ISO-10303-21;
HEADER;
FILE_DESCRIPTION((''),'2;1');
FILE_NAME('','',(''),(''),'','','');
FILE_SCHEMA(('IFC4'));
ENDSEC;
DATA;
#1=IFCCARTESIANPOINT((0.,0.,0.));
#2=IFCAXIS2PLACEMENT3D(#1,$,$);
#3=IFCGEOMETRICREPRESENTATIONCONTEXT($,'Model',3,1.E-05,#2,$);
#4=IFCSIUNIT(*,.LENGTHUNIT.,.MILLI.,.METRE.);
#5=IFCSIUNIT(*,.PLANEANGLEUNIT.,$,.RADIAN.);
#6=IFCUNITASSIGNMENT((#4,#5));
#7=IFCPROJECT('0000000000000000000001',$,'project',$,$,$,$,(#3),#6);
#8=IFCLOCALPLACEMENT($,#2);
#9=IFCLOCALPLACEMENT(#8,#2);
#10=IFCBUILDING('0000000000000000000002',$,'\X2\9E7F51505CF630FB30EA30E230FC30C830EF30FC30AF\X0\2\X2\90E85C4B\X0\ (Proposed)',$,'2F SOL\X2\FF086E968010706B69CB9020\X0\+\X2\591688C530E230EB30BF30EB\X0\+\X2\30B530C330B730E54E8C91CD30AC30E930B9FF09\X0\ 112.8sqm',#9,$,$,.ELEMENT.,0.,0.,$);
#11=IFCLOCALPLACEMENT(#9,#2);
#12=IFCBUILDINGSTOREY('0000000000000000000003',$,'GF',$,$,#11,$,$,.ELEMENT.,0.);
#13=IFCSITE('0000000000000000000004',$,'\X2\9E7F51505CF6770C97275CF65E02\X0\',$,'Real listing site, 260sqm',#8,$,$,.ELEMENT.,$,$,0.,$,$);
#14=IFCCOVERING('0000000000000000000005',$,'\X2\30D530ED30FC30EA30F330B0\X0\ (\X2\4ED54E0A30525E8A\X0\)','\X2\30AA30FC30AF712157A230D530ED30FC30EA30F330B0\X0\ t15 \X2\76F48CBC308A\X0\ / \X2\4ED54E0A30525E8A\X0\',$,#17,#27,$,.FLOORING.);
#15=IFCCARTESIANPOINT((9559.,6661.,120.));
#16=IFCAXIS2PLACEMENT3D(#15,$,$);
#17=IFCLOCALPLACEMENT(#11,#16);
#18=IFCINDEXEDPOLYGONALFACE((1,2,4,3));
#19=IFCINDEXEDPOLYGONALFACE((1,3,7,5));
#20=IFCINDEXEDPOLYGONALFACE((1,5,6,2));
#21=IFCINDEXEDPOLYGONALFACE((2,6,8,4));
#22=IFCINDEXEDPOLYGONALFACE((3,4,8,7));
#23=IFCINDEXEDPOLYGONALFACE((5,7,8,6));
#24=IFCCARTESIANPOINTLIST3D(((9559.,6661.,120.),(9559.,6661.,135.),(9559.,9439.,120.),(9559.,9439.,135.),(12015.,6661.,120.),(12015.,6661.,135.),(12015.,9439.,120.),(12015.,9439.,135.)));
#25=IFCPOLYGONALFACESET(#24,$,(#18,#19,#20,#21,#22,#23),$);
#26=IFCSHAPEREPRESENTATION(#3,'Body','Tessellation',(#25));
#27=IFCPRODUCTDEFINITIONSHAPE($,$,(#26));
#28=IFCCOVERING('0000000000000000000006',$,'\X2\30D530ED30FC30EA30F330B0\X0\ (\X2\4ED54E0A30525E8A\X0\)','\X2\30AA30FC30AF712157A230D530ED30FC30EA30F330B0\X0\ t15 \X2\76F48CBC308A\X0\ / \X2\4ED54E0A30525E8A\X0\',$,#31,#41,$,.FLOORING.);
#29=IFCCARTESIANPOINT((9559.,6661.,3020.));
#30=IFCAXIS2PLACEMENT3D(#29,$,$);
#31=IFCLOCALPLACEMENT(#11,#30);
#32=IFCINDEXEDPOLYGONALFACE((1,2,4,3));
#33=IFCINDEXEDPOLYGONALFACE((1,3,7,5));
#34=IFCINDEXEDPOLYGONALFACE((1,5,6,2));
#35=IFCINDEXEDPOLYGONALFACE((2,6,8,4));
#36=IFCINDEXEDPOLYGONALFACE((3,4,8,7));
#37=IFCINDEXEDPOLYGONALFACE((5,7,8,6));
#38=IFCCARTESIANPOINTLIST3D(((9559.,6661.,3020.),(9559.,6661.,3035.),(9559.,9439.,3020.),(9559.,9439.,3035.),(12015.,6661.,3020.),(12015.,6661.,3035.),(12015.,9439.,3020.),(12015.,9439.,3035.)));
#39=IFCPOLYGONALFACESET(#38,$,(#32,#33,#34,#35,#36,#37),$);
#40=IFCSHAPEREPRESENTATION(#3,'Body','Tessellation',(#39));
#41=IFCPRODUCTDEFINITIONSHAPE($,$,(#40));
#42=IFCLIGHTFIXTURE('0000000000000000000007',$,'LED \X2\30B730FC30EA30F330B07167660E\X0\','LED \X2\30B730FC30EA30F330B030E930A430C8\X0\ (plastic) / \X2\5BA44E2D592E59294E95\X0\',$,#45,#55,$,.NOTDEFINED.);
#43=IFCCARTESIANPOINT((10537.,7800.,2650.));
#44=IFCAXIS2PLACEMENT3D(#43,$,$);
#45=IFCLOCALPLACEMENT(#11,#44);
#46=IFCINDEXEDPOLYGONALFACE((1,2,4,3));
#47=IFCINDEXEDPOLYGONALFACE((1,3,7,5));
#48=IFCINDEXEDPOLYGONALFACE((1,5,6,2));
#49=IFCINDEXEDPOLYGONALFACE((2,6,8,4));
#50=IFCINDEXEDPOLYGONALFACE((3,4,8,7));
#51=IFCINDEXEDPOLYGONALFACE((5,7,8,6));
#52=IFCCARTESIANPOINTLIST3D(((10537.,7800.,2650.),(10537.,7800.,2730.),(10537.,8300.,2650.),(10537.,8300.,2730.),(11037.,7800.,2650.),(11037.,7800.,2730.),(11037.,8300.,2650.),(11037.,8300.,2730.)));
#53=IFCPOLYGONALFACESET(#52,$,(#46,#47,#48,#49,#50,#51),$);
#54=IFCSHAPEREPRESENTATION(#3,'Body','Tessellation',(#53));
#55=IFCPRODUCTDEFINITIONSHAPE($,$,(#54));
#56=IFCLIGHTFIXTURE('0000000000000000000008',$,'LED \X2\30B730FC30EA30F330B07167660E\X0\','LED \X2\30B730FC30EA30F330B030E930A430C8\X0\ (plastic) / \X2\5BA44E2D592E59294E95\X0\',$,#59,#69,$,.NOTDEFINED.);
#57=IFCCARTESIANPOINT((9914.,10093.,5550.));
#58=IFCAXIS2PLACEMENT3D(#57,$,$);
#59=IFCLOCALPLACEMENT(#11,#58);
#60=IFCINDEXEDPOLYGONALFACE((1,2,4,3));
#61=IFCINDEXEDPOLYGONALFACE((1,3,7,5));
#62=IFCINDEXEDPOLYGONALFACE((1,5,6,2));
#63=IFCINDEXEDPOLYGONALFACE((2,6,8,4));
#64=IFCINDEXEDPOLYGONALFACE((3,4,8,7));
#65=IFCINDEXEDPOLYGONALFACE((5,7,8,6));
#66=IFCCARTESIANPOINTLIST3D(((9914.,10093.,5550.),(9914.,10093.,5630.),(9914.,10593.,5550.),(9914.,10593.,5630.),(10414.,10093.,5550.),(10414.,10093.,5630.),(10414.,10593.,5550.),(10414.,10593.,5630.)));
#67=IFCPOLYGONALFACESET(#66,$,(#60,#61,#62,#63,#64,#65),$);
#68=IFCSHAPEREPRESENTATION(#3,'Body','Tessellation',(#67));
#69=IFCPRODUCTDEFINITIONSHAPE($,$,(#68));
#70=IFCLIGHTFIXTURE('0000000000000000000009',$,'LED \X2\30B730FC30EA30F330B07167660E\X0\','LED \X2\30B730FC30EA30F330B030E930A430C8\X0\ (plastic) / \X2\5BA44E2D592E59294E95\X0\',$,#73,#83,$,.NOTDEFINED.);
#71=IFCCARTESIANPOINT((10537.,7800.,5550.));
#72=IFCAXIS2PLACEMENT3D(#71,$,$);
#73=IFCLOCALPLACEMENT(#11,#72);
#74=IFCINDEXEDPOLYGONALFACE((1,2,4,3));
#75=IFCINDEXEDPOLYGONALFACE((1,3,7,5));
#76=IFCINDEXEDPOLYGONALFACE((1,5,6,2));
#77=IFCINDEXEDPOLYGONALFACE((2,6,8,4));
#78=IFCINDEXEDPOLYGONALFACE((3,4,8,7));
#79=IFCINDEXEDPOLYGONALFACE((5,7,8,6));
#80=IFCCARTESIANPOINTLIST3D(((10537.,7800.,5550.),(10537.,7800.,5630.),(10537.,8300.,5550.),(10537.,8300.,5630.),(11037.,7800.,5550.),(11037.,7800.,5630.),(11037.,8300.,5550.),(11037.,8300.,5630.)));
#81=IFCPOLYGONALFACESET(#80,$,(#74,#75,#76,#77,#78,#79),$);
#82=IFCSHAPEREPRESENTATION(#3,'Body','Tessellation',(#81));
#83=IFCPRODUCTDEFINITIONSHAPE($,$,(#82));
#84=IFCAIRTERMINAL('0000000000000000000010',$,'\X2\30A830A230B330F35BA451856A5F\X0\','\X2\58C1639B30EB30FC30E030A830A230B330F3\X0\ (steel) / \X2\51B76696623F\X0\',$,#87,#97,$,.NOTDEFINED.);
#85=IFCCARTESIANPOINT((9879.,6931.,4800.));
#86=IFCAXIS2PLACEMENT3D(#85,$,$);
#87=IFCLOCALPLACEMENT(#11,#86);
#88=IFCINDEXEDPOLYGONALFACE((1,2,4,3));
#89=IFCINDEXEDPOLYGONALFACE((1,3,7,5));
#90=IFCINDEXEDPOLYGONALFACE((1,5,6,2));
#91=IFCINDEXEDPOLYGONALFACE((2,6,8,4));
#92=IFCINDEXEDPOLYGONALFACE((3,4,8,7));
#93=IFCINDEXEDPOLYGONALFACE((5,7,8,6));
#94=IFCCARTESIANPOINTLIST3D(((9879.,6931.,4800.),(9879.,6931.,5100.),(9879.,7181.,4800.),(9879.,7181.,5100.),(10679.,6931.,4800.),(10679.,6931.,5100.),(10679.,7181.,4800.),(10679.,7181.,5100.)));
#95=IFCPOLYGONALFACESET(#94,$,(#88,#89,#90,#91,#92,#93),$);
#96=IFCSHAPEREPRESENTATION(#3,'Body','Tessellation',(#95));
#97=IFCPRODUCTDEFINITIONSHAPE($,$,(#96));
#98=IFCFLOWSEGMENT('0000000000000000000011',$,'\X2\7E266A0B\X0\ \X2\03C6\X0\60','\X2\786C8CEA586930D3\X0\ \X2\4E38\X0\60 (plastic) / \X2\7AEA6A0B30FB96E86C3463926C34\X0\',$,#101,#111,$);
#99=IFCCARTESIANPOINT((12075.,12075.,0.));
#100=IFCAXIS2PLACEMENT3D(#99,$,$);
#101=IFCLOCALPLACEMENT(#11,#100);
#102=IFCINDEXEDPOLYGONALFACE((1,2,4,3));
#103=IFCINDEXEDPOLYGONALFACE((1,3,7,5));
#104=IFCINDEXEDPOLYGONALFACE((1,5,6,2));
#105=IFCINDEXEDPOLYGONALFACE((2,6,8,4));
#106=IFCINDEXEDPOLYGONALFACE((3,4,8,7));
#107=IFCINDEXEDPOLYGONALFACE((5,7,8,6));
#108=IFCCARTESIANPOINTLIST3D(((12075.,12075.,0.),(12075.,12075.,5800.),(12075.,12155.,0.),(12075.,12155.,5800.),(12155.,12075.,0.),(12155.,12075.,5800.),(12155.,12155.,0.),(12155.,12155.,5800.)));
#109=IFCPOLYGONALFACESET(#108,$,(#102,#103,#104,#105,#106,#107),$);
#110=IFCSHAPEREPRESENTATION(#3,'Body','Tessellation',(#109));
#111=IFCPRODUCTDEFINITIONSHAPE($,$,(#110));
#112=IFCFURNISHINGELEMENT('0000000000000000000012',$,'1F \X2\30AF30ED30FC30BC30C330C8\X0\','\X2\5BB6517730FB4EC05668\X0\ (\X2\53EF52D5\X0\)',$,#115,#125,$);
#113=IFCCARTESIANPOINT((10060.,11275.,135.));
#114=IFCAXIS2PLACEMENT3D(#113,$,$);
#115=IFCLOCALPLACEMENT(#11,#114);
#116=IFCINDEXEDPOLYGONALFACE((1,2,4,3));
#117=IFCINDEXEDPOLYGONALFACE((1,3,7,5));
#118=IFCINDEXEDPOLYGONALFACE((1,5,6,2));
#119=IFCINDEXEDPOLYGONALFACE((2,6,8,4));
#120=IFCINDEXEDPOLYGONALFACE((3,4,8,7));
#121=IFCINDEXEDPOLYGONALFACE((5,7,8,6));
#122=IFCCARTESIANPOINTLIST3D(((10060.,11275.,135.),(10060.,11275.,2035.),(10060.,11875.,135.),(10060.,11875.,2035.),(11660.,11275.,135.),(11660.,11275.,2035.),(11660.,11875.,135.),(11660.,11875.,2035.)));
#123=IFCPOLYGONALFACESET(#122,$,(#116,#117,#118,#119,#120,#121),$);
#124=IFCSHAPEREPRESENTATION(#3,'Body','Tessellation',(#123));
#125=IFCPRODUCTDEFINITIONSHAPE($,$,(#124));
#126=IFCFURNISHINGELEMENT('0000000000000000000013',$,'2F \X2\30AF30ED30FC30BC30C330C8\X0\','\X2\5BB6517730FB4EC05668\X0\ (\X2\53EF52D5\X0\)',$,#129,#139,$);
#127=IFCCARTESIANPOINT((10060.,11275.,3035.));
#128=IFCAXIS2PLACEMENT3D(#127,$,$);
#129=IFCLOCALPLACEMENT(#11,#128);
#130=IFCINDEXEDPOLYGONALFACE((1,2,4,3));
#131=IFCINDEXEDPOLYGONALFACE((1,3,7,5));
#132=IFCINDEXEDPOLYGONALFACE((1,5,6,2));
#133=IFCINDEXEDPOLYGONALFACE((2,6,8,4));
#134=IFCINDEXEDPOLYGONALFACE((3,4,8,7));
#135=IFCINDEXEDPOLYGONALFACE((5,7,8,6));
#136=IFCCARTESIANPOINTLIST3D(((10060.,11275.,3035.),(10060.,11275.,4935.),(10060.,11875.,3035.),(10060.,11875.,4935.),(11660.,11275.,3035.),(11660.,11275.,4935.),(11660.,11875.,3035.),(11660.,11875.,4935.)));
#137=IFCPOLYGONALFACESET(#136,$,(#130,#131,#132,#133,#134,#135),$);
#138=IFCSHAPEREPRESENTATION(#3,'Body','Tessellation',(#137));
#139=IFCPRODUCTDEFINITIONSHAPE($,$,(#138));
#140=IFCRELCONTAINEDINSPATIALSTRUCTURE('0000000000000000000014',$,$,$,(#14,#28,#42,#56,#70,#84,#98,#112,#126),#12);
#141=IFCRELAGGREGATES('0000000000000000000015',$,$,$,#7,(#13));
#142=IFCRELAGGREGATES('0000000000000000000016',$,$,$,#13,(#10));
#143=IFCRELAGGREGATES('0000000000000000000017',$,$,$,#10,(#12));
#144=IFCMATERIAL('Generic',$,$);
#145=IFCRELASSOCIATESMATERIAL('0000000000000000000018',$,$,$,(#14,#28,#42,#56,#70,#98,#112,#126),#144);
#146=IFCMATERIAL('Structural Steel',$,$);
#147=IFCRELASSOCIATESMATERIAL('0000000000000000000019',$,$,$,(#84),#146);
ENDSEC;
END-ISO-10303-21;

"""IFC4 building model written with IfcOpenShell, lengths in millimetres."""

from ifc_helpers import new_model, si_unit, frame, frame_2d, origin, place, context, project, spatial, rectangle, extrude, material, element, save


model = new_model("IFC4")

# Units and contexts
model_context = context("Model", 3, precision=1e-05, world=origin())
ifc_project = project(units=[si_unit("LENGTHUNIT", "METRE", prefix="MILLI"), si_unit("PLANEANGLEUNIT", "RADIAN")], contexts=[model_context])

# Site, building, storey
site_placement = place(None, origin())
site = spatial("IfcSite", under=ifc_project, at=site_placement, Name="鹿児島県霧島市", ObjectType="Real listing site, 260sqm", CompositionType="ELEMENT", RefElevation=0.0)
building_placement = place(site_placement, origin())
building = spatial("IfcBuilding", under=site, at=building_placement, Name="鹿児島・リモートワーク2部屋 (Proposed)", ObjectType="2F SOL（準耐火構造+外装モルタル+サッシュ二重ガラス） 112.8sqm", CompositionType="ELEMENT", ElevationOfRefHeight=0.0, ElevationOfTerrain=0.0)
storey_placement = place(building_placement, origin())
storey = spatial("IfcBuildingStorey", under=building, at=storey_placement, Name="GF", CompositionType="ELEMENT", Elevation=0.0)

# Shared definitions
ifc_material_1 = material(Name="Structural Steel")

# Coverings
ifc_material_2 = material(Name="Generic")
covering_1_placement = place(storey_placement, frame((9559.0, 6661.0, 120.0)))
element("IfcCovering", 1, at=covering_1_placement, inside=storey, material=ifc_material_2, Name="フローリング (仕上げ床)", Description="オーク無垢フローリング t15 直貼り / 仕上げ床", PredefinedType="FLOORING", context=model_context, shape_type="SweptSolid", body=[
    extrude(rectangle(XDim=2456.0, YDim=2778.0, at=frame_2d((1228.0, 1389.0))), frame((9559.0, 6661.0, 120.0)), (0.0, 0.0, 1.0), 15.0),
])
covering_2_placement = place(storey_placement, frame((9559.0, 6661.0, 3020.0)))
element("IfcCovering", 2, at=covering_2_placement, inside=storey, material=ifc_material_2, Name="フローリング (仕上げ床)", Description="オーク無垢フローリング t15 直貼り / 仕上げ床", PredefinedType="FLOORING", context=model_context, shape_type="SweptSolid", body=[
    extrude(rectangle(XDim=2456.0, YDim=2778.0, at=frame_2d((1228.0, 1389.0))), frame((9559.0, 6661.0, 3020.0)), (0.0, 0.0, 1.0), 15.0),
])

# Light fixtures
light_fixture_1_placement = place(storey_placement, frame((10537.0, 7800.0, 2650.0)))
element("IfcLightFixture", 3, at=light_fixture_1_placement, inside=storey, material=ifc_material_2, Name="LED シーリング照明", Description="LED シーリングライト (plastic) / 室中央天井", PredefinedType="NOTDEFINED", context=model_context, shape_type="SweptSolid", body=[
    extrude(rectangle(XDim=500.0, YDim=500.0, at=frame_2d((250.0, 250.0))), frame((10537.0, 7800.0, 2650.0)), (0.0, 0.0, 1.0), 80.0),
])
light_fixture_2_placement = place(storey_placement, frame((9914.0, 10093.0, 5550.0)))
element("IfcLightFixture", 4, at=light_fixture_2_placement, inside=storey, material=ifc_material_2, Name="LED シーリング照明", Description="LED シーリングライト (plastic) / 室中央天井", PredefinedType="NOTDEFINED", context=model_context, shape_type="SweptSolid", body=[
    extrude(rectangle(XDim=500.0, YDim=500.0, at=frame_2d((250.0, 250.0))), frame((9914.0, 10093.0, 5550.0)), (0.0, 0.0, 1.0), 80.0),
])
light_fixture_3_placement = place(storey_placement, frame((10537.0, 7800.0, 5550.0)))
element("IfcLightFixture", 5, at=light_fixture_3_placement, inside=storey, material=ifc_material_2, Name="LED シーリング照明", Description="LED シーリングライト (plastic) / 室中央天井", PredefinedType="NOTDEFINED", context=model_context, shape_type="SweptSolid", body=[
    extrude(rectangle(XDim=500.0, YDim=500.0, at=frame_2d((250.0, 250.0))), frame((10537.0, 7800.0, 5550.0)), (0.0, 0.0, 1.0), 80.0),
])

# Air terminal
air_terminal_placement = place(storey_placement, frame((9879.0, 6931.0, 4800.0)))
element("IfcAirTerminal", 6, at=air_terminal_placement, inside=storey, material=ifc_material_1, Name="エアコン室内機", Description="壁掛ルームエアコン (steel) / 冷暖房", PredefinedType="NOTDEFINED", context=model_context, shape_type="SweptSolid", body=[
    extrude(rectangle(XDim=800.0, YDim=250.0, at=frame_2d((400.0, 125.0))), frame((9879.0, 6931.0, 4800.0)), (0.0, 0.0, 1.0), 300.0),
])

# Flow segment
flow_segment_placement = place(storey_placement, frame((12075.0, 12075.0, 0.0)))
element("IfcFlowSegment", 7, at=flow_segment_placement, inside=storey, material=ifc_material_2, Name="縦樋 φ60", Description="硬質塩ビ 丸60 (plastic) / 竪樋・雨水排水", context=model_context, shape_type="SweptSolid", body=[
    extrude(rectangle(XDim=80.0, YDim=80.0, at=frame_2d((40.0, 40.0))), frame((12075.0, 12075.0, 0.0)), (0.0, 0.0, 1.0), 5800.0),
])

# Furnishing elements
furnishing_1_placement = place(storey_placement, frame((10060.0, 11275.0, 135.0)))
element("IfcFurnishingElement", 8, at=furnishing_1_placement, inside=storey, material=ifc_material_2, Name="1F クローゼット", Description="家具・什器 (可動)", context=model_context, shape_type="SweptSolid", body=[
    extrude(rectangle(XDim=1600.0, YDim=600.0, at=frame_2d((800.0, 300.0))), frame((10060.0, 11275.0, 135.0)), (0.0, 0.0, 1.0), 1900.0),
])
furnishing_2_placement = place(storey_placement, frame((10060.0, 11275.0, 3035.0)))
element("IfcFurnishingElement", 9, at=furnishing_2_placement, inside=storey, material=ifc_material_2, Name="2F クローゼット", Description="家具・什器 (可動)", context=model_context, shape_type="SweptSolid", body=[
    extrude(rectangle(XDim=1600.0, YDim=600.0, at=frame_2d((800.0, 300.0))), frame((10060.0, 11275.0, 3035.0)), (0.0, 0.0, 1.0), 1900.0),
])

save(model, "model.ifc")
